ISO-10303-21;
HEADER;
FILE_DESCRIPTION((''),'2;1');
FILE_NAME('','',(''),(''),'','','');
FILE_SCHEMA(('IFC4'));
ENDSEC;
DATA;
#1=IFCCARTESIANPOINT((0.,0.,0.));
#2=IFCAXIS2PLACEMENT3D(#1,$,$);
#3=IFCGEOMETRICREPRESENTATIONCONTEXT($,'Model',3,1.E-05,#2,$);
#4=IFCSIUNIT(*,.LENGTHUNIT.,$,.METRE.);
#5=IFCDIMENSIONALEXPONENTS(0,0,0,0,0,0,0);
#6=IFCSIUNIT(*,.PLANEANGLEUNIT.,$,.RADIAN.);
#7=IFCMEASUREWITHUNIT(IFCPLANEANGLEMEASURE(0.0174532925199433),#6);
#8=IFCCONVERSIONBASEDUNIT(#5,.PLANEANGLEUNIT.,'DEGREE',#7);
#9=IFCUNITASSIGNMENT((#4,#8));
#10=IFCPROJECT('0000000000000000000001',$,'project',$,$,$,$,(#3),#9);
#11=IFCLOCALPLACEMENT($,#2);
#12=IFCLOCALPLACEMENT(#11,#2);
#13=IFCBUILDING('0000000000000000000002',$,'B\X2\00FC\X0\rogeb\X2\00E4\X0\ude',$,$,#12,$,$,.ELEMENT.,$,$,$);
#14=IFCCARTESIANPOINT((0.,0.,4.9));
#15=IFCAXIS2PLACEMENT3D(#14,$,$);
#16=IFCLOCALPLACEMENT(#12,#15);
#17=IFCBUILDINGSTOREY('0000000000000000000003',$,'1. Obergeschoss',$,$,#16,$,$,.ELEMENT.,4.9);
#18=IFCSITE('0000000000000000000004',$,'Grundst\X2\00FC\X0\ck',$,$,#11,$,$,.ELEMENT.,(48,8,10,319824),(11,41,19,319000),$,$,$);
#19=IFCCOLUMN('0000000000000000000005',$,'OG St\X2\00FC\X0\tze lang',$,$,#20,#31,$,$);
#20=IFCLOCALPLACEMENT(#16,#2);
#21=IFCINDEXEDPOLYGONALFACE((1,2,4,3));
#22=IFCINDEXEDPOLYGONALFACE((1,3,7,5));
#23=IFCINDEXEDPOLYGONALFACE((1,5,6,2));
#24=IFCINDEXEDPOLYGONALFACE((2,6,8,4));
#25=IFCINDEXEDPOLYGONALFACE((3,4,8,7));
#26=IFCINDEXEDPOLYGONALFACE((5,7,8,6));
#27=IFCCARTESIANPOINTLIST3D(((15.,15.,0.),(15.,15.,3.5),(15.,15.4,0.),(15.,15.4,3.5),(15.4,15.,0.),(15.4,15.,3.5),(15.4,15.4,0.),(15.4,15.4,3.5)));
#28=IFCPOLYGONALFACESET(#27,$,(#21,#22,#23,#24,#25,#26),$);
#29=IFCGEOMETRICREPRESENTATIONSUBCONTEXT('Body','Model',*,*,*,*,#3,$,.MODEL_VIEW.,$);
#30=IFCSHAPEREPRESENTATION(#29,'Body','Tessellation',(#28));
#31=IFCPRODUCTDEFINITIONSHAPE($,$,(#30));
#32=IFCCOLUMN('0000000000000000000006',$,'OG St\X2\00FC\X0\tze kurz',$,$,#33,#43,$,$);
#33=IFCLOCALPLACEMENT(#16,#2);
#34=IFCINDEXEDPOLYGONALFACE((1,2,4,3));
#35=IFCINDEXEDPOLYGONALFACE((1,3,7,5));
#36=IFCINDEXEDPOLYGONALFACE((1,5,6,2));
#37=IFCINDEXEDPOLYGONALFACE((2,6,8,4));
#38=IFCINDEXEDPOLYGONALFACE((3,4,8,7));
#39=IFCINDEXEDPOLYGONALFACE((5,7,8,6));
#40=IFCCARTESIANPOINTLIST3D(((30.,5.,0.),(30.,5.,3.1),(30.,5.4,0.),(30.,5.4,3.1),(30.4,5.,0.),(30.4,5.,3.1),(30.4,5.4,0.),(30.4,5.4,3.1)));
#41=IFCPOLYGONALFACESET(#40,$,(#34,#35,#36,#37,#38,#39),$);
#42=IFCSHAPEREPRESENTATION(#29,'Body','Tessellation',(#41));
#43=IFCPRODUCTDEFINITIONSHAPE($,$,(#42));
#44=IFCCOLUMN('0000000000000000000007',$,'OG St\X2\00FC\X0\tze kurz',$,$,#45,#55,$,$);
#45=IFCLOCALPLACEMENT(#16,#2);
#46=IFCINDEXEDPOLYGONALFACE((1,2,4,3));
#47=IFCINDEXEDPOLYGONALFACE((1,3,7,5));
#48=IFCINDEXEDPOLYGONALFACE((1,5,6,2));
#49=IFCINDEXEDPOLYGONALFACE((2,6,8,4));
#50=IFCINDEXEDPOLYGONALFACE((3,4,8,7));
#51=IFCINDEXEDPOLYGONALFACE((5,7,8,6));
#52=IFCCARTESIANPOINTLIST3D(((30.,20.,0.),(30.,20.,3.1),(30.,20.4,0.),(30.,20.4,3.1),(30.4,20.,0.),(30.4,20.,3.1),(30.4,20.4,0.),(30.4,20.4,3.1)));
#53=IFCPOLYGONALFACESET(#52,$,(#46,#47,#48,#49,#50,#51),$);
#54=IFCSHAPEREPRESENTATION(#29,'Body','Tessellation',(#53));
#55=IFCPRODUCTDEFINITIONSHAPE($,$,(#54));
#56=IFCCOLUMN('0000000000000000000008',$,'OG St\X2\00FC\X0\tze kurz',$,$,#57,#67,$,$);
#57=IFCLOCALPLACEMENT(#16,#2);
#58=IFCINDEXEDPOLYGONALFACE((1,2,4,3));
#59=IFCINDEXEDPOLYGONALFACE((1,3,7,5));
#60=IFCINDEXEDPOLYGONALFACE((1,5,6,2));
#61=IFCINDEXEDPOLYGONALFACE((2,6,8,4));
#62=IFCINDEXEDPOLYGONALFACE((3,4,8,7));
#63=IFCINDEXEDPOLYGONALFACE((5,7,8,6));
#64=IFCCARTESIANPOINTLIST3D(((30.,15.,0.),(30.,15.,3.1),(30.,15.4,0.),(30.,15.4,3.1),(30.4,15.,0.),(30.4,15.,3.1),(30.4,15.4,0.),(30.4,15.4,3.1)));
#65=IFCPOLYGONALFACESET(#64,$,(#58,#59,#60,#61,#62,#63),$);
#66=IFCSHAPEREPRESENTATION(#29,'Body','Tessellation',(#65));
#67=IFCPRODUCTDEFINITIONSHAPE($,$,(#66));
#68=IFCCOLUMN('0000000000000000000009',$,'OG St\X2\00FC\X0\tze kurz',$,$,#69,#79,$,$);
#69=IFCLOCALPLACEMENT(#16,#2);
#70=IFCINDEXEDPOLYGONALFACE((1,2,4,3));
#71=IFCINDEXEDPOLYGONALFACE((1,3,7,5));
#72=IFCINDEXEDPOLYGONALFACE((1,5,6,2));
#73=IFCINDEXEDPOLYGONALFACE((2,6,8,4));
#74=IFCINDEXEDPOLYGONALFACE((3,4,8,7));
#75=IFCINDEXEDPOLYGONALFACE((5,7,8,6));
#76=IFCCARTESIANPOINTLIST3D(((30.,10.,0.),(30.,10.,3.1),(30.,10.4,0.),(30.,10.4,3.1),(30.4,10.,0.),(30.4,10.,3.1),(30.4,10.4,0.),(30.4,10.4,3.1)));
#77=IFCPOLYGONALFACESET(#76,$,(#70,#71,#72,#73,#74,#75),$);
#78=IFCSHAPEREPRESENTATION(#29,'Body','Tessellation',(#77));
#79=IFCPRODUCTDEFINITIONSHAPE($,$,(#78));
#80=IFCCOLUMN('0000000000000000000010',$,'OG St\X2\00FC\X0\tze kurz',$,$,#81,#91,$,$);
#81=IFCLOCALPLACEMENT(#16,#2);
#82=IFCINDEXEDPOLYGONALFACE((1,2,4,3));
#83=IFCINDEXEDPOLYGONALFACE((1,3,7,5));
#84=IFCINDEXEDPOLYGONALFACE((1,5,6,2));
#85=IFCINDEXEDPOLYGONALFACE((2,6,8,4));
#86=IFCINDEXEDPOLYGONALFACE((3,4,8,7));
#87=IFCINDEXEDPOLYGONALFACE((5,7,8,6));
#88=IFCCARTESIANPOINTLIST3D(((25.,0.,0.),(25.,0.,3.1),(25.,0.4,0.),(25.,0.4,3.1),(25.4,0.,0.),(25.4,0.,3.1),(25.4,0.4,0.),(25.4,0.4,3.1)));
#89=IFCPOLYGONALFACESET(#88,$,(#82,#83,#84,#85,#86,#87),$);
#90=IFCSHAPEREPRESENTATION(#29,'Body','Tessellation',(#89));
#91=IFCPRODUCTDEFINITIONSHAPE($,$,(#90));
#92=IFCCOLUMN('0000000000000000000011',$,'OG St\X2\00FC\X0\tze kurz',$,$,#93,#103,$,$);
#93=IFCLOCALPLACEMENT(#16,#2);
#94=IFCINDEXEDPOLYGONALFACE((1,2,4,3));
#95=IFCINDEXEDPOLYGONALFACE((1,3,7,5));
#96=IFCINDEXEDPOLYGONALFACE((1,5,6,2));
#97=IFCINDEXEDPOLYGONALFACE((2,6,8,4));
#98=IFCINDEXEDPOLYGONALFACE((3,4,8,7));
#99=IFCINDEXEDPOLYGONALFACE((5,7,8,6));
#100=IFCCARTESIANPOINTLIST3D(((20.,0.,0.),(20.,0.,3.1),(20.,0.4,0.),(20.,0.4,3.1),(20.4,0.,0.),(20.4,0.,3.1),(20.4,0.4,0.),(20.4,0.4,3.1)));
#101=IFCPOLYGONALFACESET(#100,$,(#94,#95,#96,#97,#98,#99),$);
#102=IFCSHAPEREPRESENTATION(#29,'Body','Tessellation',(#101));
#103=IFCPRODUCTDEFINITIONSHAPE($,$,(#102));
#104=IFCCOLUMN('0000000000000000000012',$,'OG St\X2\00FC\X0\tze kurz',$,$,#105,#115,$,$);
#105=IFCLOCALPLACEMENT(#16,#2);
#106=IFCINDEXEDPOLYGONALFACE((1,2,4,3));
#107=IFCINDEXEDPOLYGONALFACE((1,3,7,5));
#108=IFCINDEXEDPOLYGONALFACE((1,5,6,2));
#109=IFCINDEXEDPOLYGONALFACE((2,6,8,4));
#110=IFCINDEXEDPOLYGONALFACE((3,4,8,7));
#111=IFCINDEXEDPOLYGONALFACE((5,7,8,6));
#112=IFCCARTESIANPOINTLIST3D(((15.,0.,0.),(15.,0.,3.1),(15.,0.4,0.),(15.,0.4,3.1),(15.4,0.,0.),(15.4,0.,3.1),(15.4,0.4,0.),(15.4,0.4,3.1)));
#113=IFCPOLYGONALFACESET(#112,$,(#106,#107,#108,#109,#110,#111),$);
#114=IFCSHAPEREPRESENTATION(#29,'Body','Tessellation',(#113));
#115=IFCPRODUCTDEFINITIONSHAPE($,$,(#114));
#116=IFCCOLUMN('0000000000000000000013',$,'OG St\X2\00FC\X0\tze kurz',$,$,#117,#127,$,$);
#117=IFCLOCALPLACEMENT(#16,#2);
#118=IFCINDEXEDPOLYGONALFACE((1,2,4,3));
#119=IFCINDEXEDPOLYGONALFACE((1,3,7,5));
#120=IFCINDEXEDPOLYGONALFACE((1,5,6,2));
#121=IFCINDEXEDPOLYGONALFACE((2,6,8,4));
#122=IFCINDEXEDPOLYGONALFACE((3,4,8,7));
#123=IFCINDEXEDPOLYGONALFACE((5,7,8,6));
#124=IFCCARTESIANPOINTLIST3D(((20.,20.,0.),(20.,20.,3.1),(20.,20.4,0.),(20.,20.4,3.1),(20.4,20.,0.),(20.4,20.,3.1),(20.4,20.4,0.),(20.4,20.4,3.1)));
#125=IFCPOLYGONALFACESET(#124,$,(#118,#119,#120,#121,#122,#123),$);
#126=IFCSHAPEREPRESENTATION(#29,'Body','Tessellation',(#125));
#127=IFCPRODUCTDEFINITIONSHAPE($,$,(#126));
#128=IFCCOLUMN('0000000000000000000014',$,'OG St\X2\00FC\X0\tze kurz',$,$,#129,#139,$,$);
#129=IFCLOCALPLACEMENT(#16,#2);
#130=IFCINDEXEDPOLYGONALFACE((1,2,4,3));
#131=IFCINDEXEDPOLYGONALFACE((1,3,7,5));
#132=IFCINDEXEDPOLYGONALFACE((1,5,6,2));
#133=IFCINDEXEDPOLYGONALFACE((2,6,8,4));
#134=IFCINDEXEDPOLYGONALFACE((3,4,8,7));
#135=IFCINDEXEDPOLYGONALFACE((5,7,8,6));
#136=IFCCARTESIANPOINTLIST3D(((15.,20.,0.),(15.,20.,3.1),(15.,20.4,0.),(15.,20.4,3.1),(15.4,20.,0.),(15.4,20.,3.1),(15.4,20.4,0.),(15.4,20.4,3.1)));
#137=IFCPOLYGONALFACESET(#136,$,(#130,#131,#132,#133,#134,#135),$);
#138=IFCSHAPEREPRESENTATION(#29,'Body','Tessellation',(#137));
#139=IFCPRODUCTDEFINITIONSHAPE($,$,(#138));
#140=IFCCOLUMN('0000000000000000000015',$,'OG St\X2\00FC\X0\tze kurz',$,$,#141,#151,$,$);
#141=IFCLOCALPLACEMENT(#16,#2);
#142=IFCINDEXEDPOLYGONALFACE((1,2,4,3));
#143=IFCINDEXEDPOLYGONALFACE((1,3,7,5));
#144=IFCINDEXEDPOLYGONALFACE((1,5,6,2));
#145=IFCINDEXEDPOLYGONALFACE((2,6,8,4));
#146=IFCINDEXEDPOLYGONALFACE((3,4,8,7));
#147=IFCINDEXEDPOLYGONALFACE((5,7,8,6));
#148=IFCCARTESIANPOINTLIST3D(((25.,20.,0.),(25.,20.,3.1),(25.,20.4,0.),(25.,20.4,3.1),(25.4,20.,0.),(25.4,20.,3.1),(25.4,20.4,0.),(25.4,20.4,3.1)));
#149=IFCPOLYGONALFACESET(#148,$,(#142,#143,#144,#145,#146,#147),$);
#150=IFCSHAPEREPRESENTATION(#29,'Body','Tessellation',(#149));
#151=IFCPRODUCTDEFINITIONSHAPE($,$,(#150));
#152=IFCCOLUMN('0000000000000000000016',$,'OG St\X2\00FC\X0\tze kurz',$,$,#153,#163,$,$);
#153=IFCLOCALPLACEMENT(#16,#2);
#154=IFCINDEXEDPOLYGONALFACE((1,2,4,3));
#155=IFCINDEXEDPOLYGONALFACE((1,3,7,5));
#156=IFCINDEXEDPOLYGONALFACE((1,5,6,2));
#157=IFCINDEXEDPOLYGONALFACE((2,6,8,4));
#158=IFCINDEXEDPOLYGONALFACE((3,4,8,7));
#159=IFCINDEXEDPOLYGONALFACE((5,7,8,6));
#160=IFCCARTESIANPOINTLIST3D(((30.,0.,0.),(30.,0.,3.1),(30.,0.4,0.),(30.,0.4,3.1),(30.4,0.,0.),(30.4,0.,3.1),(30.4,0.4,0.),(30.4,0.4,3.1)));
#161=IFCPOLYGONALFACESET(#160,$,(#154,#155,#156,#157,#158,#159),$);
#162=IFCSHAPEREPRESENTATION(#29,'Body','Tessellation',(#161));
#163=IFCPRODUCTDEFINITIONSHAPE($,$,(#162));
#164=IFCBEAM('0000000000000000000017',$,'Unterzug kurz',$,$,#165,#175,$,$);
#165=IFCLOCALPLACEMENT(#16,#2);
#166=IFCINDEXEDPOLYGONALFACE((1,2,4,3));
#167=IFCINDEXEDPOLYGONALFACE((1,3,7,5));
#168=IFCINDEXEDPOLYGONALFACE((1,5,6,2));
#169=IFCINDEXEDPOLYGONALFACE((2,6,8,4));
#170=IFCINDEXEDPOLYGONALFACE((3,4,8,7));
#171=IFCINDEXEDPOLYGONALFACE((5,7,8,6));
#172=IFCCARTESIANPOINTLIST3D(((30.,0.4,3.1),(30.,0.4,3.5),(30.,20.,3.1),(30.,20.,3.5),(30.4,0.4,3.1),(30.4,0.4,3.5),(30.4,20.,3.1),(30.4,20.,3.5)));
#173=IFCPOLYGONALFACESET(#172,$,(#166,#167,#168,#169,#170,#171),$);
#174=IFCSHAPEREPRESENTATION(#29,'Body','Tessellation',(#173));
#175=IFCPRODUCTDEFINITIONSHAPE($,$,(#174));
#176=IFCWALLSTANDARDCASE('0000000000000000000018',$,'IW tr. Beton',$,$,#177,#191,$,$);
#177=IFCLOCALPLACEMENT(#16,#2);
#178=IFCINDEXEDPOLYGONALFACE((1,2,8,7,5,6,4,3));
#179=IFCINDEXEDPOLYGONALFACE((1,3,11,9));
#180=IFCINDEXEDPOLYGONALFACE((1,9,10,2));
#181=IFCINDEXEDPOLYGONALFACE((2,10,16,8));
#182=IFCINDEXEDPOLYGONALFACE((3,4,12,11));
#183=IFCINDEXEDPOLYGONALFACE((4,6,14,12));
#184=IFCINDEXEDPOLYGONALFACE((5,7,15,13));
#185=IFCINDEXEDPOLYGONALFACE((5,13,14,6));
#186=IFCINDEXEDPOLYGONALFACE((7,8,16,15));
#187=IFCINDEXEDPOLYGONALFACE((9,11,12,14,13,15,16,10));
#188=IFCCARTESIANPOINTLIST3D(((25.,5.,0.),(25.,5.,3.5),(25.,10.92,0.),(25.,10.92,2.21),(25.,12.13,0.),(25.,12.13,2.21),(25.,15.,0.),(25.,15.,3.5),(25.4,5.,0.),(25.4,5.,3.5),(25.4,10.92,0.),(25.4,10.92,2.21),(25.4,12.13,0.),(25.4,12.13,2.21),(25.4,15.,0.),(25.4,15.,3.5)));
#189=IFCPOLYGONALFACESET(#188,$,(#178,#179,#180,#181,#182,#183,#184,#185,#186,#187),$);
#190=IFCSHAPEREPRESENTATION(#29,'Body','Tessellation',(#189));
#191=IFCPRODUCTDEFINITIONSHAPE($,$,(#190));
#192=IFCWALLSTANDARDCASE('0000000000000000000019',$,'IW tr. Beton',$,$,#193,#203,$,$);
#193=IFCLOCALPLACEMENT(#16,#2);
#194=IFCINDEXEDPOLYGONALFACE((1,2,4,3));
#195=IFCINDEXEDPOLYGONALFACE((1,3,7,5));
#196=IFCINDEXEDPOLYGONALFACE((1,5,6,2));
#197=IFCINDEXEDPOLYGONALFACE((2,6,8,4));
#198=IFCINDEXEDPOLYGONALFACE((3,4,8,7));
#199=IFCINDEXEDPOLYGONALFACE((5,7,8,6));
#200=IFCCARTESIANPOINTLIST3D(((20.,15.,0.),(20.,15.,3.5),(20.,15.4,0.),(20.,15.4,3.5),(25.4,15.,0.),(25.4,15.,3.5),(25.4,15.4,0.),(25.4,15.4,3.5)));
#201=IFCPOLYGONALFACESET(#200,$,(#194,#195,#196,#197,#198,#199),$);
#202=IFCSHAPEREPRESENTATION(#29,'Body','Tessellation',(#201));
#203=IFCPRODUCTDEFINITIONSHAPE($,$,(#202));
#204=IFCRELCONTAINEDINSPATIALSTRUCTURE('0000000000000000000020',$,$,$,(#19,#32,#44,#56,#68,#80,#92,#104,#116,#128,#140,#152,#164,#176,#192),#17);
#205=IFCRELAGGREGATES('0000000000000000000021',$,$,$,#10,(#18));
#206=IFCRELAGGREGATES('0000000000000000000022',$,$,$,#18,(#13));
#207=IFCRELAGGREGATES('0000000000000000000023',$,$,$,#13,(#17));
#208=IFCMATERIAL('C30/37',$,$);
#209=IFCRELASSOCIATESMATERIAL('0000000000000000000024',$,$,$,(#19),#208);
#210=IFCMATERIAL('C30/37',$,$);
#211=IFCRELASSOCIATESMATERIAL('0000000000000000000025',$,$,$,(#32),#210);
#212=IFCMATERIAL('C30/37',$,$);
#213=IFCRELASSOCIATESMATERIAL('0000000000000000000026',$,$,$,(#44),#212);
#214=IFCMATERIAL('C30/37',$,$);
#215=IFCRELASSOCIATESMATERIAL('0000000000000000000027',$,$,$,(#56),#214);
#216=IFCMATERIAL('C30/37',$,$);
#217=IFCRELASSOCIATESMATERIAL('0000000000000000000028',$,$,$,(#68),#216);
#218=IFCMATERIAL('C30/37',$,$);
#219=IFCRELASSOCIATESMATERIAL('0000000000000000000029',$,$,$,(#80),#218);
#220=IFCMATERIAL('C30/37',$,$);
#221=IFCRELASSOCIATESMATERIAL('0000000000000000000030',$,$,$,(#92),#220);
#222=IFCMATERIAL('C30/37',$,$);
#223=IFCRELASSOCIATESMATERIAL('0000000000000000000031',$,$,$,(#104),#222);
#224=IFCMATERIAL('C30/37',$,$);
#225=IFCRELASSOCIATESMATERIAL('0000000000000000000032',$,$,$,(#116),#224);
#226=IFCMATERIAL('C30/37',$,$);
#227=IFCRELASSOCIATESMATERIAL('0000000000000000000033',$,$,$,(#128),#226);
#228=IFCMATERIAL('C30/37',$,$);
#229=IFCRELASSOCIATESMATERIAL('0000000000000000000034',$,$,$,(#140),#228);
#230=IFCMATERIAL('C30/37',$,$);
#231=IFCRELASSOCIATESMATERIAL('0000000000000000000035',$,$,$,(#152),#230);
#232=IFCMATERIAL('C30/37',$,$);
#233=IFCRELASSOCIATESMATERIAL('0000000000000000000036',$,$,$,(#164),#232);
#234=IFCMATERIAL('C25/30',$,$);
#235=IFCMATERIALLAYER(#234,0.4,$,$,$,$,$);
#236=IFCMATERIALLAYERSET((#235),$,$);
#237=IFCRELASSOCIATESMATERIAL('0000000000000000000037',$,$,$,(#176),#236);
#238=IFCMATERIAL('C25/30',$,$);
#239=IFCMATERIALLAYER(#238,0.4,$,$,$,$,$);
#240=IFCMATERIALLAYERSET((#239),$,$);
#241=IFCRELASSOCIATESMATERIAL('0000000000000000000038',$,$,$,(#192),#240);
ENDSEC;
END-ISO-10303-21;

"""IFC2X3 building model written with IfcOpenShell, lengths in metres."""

from ifc_helpers import new_model, entity, si_unit, converted_unit, frame, frame_2d, origin, origin_with_axes, place, context, subcontext, project, spatial, polyline, rectangle, outline, extrude, material, layer, layer_set, layer_usage, element, save


model = new_model("IFC2X3")

# Units and contexts
model_context = context("Model", 3, precision=1e-05, world=origin())
body_context = subcontext(model_context, "Body", "Model", "MODEL_VIEW")
ifc_project = project(units=[si_unit("LENGTHUNIT", "METRE"), converted_unit("PLANEANGLEUNIT", "DEGREE", entity("IfcPlaneAngleMeasure", 0.0174532925199433), si_unit("PLANEANGLEUNIT", "RADIAN"), dimensions=[0, 0, 0, 0, 0, 0, 0])], contexts=[model_context])

# Site, building, storey
site_placement = place(None, origin())
site = spatial("IfcSite", under=ifc_project, at=site_placement, Name="Grundstück", CompositionType="ELEMENT", RefLatitude=(48, 8, 10, 319824), RefLongitude=(11, 41, 19, 319000))
building_placement = place(site_placement, origin())
building = spatial("IfcBuilding", under=site, at=building_placement, Name="Bürogebäude", CompositionType="ELEMENT")
storey_placement = place(building_placement, frame((0.0, 0.0, 4.9)))
storey = spatial("IfcBuildingStorey", under=building, at=storey_placement, Name="1. Obergeschoss", CompositionType="ELEMENT", Elevation=4.9)

# Columns
ifc_material_1 = material(Name="C30/37")
column_1_placement = place(storey_placement, frame((15.0, 15.0, 0.0)))
element("IfcColumn", 1, at=column_1_placement, inside=storey, material=ifc_material_1, Name="OG Stütze lang", context=body_context, shape_type="SweptSolid", body=[
    extrude(rectangle(XDim=0.4, YDim=0.4, at=frame_2d((0.2, 0.2), x_axis=(1.0, 0.0))), origin_with_axes(), (0.0, 0.0, 1.0), 3.5),
])
ifc_material_2 = material(Name="C30/37")
column_2_placement = place(storey_placement, frame((30.0, 5.0, 0.0)))
element("IfcColumn", 2, at=column_2_placement, inside=storey, material=ifc_material_2, Name="OG Stütze kurz", context=body_context, shape_type="SweptSolid", body=[
    extrude(rectangle(XDim=0.4, YDim=0.4, at=frame_2d((0.2, 0.2), x_axis=(1.0, 0.0))), origin_with_axes(), (0.0, 0.0, 1.0), 3.1),
])
ifc_material_3 = material(Name="C30/37")
column_3_placement = place(storey_placement, frame((30.0, 20.0, 0.0)))
element("IfcColumn", 3, at=column_3_placement, inside=storey, material=ifc_material_3, Name="OG Stütze kurz", context=body_context, shape_type="SweptSolid", body=[
    extrude(rectangle(XDim=0.4, YDim=0.4, at=frame_2d((0.2, 0.2), x_axis=(1.0, 0.0))), origin_with_axes(), (0.0, 0.0, 1.0), 3.1),
])
ifc_material_4 = material(Name="C30/37")
column_4_placement = place(storey_placement, frame((30.0, 15.0, 0.0)))
element("IfcColumn", 4, at=column_4_placement, inside=storey, material=ifc_material_4, Name="OG Stütze kurz", context=body_context, shape_type="SweptSolid", body=[
    extrude(rectangle(XDim=0.4, YDim=0.4, at=frame_2d((0.2, 0.2), x_axis=(1.0, 0.0))), origin_with_axes(), (0.0, 0.0, 1.0), 3.1),
])
ifc_material_5 = material(Name="C30/37")
column_5_placement = place(storey_placement, frame((30.0, 10.0, 0.0)))
element("IfcColumn", 5, at=column_5_placement, inside=storey, material=ifc_material_5, Name="OG Stütze kurz", context=body_context, shape_type="SweptSolid", body=[
    extrude(rectangle(XDim=0.4, YDim=0.4, at=frame_2d((0.2, 0.2), x_axis=(1.0, 0.0))), origin_with_axes(), (0.0, 0.0, 1.0), 3.1),
])
ifc_material_6 = material(Name="C30/37")
column_6_placement = place(storey_placement, frame((25.0, 0.0, 0.0)))
element("IfcColumn", 6, at=column_6_placement, inside=storey, material=ifc_material_6, Name="OG Stütze kurz", context=body_context, shape_type="SweptSolid", body=[
    extrude(rectangle(XDim=0.4, YDim=0.4, at=frame_2d((0.2, 0.2), x_axis=(1.0, 0.0))), origin_with_axes(), (0.0, 0.0, 1.0), 3.1),
])
ifc_material_7 = material(Name="C30/37")
column_7_placement = place(storey_placement, frame((20.0, 0.0, 0.0)))
element("IfcColumn", 7, at=column_7_placement, inside=storey, material=ifc_material_7, Name="OG Stütze kurz", context=body_context, shape_type="SweptSolid", body=[
    extrude(rectangle(XDim=0.4, YDim=0.4, at=frame_2d((0.2, 0.2), x_axis=(1.0, 0.0))), origin_with_axes(), (0.0, 0.0, 1.0), 3.1),
])
ifc_material_8 = material(Name="C30/37")
column_8_placement = place(storey_placement, frame((15.0, 0.0, 0.0)))
element("IfcColumn", 8, at=column_8_placement, inside=storey, material=ifc_material_8, Name="OG Stütze kurz", context=body_context, shape_type="SweptSolid", body=[
    extrude(rectangle(XDim=0.4, YDim=0.4, at=frame_2d((0.2, 0.2), x_axis=(1.0, 0.0))), origin_with_axes(), (0.0, 0.0, 1.0), 3.1),
])
ifc_material_9 = material(Name="C30/37")
column_9_placement = place(storey_placement, frame((20.0, 20.0, 0.0)))
element("IfcColumn", 9, at=column_9_placement, inside=storey, material=ifc_material_9, Name="OG Stütze kurz", context=body_context, shape_type="SweptSolid", body=[
    extrude(rectangle(XDim=0.4, YDim=0.4, at=frame_2d((0.2, 0.2), x_axis=(1.0, 0.0))), origin_with_axes(), (0.0, 0.0, 1.0), 3.1),
])
ifc_material_10 = material(Name="C30/37")
column_10_placement = place(storey_placement, frame((15.0, 20.0, 0.0)))
element("IfcColumn", 10, at=column_10_placement, inside=storey, material=ifc_material_10, Name="OG Stütze kurz", context=body_context, shape_type="SweptSolid", body=[
    extrude(rectangle(XDim=0.4, YDim=0.4, at=frame_2d((0.2, 0.2), x_axis=(1.0, 0.0))), origin_with_axes(), (0.0, 0.0, 1.0), 3.1),
])
ifc_material_11 = material(Name="C30/37")
column_11_placement = place(storey_placement, frame((25.0, 20.0, 0.0)))
element("IfcColumn", 11, at=column_11_placement, inside=storey, material=ifc_material_11, Name="OG Stütze kurz", context=body_context, shape_type="SweptSolid", body=[
    extrude(rectangle(XDim=0.4, YDim=0.4, at=frame_2d((0.2, 0.2), x_axis=(1.0, 0.0))), origin_with_axes(), (0.0, 0.0, 1.0), 3.1),
])
ifc_material_12 = material(Name="C30/37")
column_12_placement = place(storey_placement, frame((30.0, 0.0, 0.0)))
element("IfcColumn", 12, at=column_12_placement, inside=storey, material=ifc_material_12, Name="OG Stütze kurz", context=body_context, shape_type="SweptSolid", body=[
    extrude(rectangle(XDim=0.4, YDim=0.4, at=frame_2d((0.2, 0.2), x_axis=(1.0, 0.0))), origin_with_axes(), (0.0, 0.0, 1.0), 3.1),
])

# Beam
ifc_material_13 = material(Name="C30/37")
beam_placement = place(storey_placement, frame((30.4, 0.4, 3.1), z_axis=(0.0, 0.0, 1.0), x_axis=(0.0, 1.0, 0.0)))
element("IfcBeam", 13, at=beam_placement, inside=storey, material=ifc_material_13, Name="Unterzug kurz", context=body_context, shape_type="SweptSolid", body=[
    extrude(rectangle(XDim=0.4, YDim=0.4, at=frame_2d((0.2, 0.2), x_axis=(1.0, 0.0))), frame((0.0, 0.0, 0.0), z_axis=(1.0, 0.0, 0.0), x_axis=(0.0, 1.0, 0.0)), (0.0, 0.0, 1.0), 19.6),
])

# Wall, opening
ifc_material_14 = material(Name="C25/30")
ifc_layer_1 = layer(ifc_material_14, 0.4)
ifc_layer_set_1 = layer_set([ifc_layer_1])
ifc_layer_usage_1 = layer_usage(ifc_layer_set_1, "AXIS2", "POSITIVE", -0.2)
wall_1_placement = place(storey_placement, frame((25.0, 15.0, 0.0), z_axis=(0.0, 0.0, 1.0), x_axis=(0.0, -1.0, 0.0)))
wall_1 = element("IfcWallStandardCase", 14, at=wall_1_placement, inside=storey, material=ifc_layer_usage_1, Name="IW tr. Beton", context=body_context, shape_type="SweptSolid", body=[
    extrude(rectangle(XDim=10.0, YDim=0.4, at=frame_2d((5.0, 0.2), x_axis=(1.0, 0.0))), origin_with_axes(), (0.0, 0.0, 1.0), 3.5),
])
opening_1_placement = place(wall_1_placement, frame((2.87, 0.0, 0.0), z_axis=(0.0, 1.0, 0.0), x_axis=(0.0, 0.0, 1.0)))
element("IfcOpeningElement", 15, at=opening_1_placement, cuts=wall_1, ObjectType="Opening", context=body_context, shape_type="SweptSolid", body=[
    extrude(outline(polyline([(0.0, 1.21), (2.21, 1.21), (2.21, 0.0), (0.0, 0.0), (0.0, 1.21)])), origin_with_axes(), (0.0, 0.0, 1.0), 0.4),
])

# Wall
ifc_material_15 = material(Name="C25/30")
ifc_layer_2 = layer(ifc_material_15, 0.4)
ifc_layer_set_2 = layer_set([ifc_layer_2])
ifc_layer_usage_2 = layer_usage(ifc_layer_set_2, "AXIS2", "POSITIVE", -0.2)
wall_2_placement = place(storey_placement, frame((20.0, 15.0, 0.0)))
element("IfcWallStandardCase", 16, at=wall_2_placement, inside=storey, material=ifc_layer_usage_2, Name="IW tr. Beton", context=body_context, shape_type="SweptSolid", body=[
    extrude(rectangle(XDim=5.4, YDim=0.4, at=frame_2d((2.7, 0.2), x_axis=(1.0, 0.0))), origin_with_axes(), (0.0, 0.0, 1.0), 3.5),
])

save(model, "model.ifc")
